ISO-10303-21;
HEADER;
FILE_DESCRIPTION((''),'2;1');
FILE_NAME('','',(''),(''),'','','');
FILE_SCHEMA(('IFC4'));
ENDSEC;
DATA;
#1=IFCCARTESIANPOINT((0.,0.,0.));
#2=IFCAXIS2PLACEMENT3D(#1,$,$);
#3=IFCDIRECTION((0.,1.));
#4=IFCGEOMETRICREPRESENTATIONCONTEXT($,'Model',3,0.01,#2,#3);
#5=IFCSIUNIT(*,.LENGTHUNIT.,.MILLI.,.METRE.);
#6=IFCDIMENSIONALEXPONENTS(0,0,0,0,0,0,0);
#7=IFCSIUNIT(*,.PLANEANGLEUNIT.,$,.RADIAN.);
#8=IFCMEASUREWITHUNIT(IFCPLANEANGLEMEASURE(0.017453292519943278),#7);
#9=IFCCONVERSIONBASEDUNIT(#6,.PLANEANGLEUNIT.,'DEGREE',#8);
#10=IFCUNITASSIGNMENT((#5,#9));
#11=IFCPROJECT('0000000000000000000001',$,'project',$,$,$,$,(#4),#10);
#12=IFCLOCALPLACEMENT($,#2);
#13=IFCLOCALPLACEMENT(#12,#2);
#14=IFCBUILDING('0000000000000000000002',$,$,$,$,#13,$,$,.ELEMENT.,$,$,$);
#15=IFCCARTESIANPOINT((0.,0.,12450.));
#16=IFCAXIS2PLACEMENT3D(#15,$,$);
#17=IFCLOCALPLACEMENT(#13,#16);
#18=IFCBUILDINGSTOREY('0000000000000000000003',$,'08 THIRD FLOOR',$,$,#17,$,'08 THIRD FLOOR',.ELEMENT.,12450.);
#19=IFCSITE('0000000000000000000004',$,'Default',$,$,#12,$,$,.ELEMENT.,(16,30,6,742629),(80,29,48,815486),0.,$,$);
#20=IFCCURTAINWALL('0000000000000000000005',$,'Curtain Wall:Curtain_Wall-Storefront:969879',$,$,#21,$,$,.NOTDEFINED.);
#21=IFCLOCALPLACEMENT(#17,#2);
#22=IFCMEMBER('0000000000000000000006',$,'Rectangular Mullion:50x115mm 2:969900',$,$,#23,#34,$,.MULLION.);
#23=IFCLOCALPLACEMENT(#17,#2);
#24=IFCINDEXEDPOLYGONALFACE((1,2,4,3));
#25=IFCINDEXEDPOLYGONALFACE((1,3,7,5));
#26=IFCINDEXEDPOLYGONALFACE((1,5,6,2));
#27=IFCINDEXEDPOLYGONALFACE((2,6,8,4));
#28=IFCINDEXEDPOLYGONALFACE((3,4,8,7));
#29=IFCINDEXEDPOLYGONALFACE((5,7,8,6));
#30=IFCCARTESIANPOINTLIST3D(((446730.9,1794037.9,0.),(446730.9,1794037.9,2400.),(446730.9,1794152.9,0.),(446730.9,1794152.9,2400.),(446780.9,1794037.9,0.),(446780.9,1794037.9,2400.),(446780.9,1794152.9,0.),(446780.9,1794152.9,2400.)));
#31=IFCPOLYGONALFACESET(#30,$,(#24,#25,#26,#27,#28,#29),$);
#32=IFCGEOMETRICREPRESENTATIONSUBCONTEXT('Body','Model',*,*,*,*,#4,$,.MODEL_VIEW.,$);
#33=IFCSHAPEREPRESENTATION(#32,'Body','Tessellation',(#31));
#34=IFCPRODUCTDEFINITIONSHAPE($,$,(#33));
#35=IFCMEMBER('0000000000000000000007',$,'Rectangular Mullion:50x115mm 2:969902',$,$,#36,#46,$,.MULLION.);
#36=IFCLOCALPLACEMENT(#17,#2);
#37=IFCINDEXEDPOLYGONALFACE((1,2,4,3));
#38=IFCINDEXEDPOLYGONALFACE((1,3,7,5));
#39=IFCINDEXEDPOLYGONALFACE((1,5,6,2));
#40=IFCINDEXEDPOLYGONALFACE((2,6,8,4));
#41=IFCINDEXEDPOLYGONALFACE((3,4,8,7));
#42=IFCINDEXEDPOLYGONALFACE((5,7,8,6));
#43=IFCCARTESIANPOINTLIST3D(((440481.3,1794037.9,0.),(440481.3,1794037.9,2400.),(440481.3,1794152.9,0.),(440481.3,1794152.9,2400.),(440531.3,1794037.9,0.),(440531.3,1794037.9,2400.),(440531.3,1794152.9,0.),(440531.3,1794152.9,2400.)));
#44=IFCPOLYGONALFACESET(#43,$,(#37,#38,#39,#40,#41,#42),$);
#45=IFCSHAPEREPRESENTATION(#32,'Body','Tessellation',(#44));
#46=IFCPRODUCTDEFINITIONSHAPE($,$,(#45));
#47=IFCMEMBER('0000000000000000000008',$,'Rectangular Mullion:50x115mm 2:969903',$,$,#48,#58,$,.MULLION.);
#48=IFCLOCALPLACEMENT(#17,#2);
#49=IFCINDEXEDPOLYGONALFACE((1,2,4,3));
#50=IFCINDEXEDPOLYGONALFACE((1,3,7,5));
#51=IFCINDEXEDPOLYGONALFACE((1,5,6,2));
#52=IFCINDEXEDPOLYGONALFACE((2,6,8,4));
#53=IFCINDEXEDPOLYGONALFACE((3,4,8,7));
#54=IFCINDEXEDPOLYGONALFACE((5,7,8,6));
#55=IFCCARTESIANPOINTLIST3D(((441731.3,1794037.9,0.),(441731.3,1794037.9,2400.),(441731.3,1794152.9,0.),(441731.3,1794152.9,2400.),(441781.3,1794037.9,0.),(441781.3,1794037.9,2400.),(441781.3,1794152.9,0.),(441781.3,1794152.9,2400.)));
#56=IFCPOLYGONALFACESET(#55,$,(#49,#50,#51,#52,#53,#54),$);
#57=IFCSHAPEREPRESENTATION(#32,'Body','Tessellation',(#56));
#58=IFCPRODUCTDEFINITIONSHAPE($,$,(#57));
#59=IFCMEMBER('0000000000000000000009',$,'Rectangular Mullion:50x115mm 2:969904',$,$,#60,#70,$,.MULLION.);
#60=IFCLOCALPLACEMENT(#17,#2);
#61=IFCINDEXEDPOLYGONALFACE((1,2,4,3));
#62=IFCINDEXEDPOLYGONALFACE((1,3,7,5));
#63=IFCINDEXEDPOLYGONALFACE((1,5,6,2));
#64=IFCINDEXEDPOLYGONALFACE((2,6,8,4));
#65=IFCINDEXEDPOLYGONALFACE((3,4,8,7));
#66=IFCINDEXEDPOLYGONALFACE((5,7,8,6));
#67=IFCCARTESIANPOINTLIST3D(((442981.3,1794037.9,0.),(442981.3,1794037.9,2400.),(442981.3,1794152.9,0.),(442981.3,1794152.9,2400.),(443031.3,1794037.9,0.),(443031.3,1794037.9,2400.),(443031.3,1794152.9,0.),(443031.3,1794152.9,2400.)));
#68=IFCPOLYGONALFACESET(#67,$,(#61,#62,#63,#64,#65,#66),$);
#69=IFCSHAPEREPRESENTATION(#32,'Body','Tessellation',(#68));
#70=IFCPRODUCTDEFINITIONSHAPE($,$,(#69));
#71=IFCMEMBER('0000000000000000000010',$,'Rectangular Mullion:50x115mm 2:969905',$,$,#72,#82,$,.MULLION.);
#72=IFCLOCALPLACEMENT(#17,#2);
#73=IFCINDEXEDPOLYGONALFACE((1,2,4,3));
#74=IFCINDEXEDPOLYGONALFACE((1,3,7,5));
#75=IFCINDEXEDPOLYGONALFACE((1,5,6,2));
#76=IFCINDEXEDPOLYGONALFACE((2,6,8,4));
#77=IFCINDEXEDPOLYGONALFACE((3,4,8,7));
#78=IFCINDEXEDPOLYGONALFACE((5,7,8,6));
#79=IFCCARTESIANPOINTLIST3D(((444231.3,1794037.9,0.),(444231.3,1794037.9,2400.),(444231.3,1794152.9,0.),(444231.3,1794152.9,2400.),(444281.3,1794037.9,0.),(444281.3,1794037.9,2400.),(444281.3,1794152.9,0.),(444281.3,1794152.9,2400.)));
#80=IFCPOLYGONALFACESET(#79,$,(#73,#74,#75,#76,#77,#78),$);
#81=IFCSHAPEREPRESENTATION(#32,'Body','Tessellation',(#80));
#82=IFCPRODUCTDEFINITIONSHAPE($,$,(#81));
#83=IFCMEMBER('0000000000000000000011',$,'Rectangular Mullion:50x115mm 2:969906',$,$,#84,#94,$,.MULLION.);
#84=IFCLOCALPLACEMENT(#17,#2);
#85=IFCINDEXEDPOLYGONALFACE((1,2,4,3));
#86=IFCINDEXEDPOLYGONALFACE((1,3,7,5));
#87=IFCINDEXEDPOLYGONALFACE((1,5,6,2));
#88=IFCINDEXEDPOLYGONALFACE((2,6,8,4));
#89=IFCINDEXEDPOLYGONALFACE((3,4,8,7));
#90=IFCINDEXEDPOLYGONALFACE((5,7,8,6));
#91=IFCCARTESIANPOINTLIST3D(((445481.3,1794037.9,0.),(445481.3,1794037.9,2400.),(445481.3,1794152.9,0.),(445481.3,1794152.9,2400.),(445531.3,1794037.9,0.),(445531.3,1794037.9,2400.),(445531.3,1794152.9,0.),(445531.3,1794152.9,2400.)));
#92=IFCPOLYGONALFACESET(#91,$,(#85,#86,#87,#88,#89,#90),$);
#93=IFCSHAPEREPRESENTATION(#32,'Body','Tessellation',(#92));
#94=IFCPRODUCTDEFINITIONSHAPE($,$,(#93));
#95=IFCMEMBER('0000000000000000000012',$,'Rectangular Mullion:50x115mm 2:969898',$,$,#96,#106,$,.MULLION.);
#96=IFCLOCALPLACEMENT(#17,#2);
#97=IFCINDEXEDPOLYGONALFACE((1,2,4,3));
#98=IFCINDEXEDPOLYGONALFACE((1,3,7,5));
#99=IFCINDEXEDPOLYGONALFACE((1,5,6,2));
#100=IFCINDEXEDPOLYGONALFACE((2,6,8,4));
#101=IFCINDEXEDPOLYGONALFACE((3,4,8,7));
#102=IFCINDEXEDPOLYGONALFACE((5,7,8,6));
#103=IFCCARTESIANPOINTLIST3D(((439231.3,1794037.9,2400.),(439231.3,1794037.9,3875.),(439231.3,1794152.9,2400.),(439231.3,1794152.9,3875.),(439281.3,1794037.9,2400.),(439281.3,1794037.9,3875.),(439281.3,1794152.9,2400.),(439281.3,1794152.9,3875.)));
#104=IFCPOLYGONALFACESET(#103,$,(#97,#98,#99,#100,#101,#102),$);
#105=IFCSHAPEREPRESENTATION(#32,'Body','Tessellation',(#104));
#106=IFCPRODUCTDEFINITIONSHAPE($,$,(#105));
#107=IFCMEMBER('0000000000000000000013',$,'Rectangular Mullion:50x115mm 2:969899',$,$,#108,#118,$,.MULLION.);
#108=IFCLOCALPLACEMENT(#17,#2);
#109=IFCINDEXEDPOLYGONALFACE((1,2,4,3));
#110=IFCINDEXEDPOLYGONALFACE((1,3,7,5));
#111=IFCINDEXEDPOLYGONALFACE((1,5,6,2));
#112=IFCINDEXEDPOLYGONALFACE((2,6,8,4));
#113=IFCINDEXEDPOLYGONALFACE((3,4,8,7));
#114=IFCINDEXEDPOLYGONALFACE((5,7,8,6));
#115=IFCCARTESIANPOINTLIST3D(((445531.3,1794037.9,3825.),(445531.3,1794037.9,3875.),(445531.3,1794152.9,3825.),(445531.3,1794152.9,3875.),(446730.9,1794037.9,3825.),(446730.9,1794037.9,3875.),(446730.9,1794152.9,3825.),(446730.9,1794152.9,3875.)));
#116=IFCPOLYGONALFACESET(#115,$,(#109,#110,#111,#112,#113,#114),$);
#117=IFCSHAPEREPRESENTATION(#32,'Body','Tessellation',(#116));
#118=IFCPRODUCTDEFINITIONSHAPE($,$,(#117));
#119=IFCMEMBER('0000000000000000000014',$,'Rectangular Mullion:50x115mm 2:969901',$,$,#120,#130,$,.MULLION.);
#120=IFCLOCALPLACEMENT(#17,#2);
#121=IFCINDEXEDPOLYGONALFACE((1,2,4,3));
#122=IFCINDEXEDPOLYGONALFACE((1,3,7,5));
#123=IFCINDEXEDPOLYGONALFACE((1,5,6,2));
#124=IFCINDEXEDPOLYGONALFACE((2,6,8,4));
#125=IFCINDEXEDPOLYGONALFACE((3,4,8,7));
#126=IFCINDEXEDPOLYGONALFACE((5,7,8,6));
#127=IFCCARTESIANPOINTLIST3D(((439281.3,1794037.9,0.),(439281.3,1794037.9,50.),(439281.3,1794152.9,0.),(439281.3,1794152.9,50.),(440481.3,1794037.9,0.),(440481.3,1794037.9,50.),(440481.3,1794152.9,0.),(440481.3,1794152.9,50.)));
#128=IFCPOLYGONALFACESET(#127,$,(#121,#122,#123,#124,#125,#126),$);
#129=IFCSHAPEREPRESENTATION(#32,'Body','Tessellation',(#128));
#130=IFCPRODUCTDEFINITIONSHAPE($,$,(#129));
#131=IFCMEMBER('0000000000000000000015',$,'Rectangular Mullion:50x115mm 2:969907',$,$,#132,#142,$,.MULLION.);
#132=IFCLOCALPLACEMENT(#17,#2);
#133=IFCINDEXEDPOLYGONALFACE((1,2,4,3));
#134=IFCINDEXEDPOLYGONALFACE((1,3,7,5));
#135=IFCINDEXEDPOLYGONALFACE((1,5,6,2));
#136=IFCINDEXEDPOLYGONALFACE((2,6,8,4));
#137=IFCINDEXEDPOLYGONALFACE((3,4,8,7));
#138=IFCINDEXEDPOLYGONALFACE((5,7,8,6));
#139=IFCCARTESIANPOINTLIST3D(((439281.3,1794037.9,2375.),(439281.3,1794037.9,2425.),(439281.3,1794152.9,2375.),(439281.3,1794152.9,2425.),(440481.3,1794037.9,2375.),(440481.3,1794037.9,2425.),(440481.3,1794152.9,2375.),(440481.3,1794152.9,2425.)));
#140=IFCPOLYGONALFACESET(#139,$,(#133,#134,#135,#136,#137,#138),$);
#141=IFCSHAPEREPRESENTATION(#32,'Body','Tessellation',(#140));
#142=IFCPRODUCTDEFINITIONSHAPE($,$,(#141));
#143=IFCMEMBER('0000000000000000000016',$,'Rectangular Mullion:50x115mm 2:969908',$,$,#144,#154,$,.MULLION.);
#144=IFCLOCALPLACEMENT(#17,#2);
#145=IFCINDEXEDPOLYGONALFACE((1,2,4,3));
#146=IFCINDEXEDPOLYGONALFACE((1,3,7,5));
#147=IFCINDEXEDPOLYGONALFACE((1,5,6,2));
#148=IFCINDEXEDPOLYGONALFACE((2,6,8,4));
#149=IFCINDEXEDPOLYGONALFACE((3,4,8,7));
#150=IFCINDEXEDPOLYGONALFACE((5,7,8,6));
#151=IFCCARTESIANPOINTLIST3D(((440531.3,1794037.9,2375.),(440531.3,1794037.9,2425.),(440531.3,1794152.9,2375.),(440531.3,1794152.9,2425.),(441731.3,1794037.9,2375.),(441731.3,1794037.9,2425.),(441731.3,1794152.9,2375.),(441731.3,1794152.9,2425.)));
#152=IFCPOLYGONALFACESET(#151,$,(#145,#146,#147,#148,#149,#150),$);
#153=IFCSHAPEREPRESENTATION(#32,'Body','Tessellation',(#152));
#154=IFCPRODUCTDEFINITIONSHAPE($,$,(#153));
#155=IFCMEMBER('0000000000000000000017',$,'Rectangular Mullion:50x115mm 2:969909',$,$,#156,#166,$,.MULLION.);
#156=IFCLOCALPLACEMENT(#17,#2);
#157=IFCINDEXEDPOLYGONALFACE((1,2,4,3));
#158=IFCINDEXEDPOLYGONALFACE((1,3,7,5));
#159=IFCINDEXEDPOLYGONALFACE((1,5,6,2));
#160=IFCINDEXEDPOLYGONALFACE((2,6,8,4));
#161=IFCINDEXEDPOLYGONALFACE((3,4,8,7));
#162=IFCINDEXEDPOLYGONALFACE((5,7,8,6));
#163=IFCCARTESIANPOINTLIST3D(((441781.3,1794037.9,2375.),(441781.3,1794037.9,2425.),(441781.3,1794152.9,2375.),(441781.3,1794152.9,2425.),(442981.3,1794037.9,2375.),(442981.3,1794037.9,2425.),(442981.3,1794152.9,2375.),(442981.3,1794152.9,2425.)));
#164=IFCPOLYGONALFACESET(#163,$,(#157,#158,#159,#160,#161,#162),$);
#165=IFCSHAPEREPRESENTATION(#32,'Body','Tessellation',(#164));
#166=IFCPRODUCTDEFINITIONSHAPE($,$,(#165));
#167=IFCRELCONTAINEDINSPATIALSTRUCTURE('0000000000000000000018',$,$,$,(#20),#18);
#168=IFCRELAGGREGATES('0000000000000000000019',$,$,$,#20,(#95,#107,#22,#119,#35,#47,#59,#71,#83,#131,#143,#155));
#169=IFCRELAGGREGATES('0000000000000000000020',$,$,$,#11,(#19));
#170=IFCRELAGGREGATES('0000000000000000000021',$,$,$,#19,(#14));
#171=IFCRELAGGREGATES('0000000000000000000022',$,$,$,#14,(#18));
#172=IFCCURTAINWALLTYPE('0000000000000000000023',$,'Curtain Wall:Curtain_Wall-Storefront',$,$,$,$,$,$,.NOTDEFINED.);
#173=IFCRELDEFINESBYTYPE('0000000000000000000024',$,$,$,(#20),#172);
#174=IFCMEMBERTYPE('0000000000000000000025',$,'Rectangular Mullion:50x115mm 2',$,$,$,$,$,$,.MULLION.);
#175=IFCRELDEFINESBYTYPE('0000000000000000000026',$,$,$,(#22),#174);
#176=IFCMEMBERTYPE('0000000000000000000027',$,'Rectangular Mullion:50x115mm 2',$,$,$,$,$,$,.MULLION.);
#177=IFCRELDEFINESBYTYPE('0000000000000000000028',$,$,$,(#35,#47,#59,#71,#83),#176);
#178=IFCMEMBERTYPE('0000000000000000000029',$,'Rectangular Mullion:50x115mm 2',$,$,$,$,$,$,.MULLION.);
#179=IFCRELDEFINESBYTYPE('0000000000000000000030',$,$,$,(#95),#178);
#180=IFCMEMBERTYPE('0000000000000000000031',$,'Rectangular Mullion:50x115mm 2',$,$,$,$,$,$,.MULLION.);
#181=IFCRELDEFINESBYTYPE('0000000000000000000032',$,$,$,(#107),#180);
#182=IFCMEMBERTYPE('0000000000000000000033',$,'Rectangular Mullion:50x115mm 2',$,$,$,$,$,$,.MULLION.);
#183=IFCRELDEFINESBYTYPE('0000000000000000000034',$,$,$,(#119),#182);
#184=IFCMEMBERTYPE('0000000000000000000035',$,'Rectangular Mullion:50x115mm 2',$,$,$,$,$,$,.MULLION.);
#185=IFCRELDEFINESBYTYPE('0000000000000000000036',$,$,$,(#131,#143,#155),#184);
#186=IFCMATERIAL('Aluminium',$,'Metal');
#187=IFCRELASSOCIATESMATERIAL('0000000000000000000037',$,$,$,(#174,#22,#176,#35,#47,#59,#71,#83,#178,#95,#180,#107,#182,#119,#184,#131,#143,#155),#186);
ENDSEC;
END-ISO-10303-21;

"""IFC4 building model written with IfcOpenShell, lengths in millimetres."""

from ifc_helpers import new_model, entity, si_unit, converted_unit, direction, frame, origin, place, context, subcontext, project, spatial, indexed_curve, outline, extrude, source, transform, mapped, material, type_object, type_shapes, element, aggregate, save


model = new_model("IFC4")

# Units and contexts
model_context = context("Model", 3, precision=0.01, world=origin(), true_north=direction((0.0, 1.0)))
body_context = subcontext(model_context, "Body", "Model", "MODEL_VIEW")
ifc_project = project(units=[si_unit("LENGTHUNIT", "METRE", prefix="MILLI"), converted_unit("PLANEANGLEUNIT", "DEGREE", entity("IfcPlaneAngleMeasure", 0.017453292519943278), si_unit("PLANEANGLEUNIT", "RADIAN"), dimensions=[0, 0, 0, 0, 0, 0, 0])], contexts=[model_context])

# Site, building, storey
site_placement = place(None, origin())
site = spatial("IfcSite", under=ifc_project, at=site_placement, Name="Default", CompositionType="ELEMENT", RefLatitude=(16, 30, 6, 742629), RefLongitude=(80, 29, 48, 815486), RefElevation=0.0)
building_placement = place(site_placement, origin())
building = spatial("IfcBuilding", under=site, at=building_placement, CompositionType="ELEMENT")
storey_placement = place(building_placement, frame((0.0, 0.0, 12450.0)))
storey = spatial("IfcBuildingStorey", under=building, at=storey_placement, Name="08 THIRD FLOOR", LongName="08 THIRD FLOOR", CompositionType="ELEMENT", Elevation=12450.0)

# Curtain wall, members
curtain_wall_type = type_object("IfcCurtainWallType", Name="Curtain Wall:Curtain_Wall-Storefront", PredefinedType="NOTDEFINED")
curtain_wall_placement = place(storey_placement, frame((0.0, 0.0, -12450.0)))
curtain_wall = element("IfcCurtainWall", 1, at=curtain_wall_placement, inside=storey, type_object=curtain_wall_type, Name="Curtain Wall:Curtain_Wall-Storefront:969879", PredefinedType="NOTDEFINED")
ifc_material_1 = material(Name="Aluminium", Category="Metal")
member_type_1 = type_object("IfcMemberType", Name="Rectangular Mullion:50x115mm 2", PredefinedType="MULLION", material=ifc_material_1)
shared_shape_1 = source(origin(), body_context, "Body", "SweptSolid", [
    extrude(outline(indexed_curve([(-25.0, -57.5), (25.0, -57.5), (25.0, 57.5), (-25.0, 57.5), (-25.0, -57.5)], self_intersect=False)), frame((-25.0, 0.0, -2400.0), z_axis=(0.0, 0.0, 1.0), x_axis=(-1.0, 0.0, 0.0)), (0.0, 0.0, 1.0), 2400.0),
])
type_shapes(member_type_1, [shared_shape_1])
member_1_placement = place(curtain_wall_placement, frame((446780.9, 1794095.4, 12450.0), z_axis=(0.0, 0.0, -1.0), x_axis=(1.0, 0.0, 0.0)))
member_1 = element("IfcMember", 2, at=member_1_placement, type_object=member_type_1, material=ifc_material_1, Name="Rectangular Mullion:50x115mm 2:969900", PredefinedType="MULLION", context=body_context, shape_type="MappedRepresentation", body=[
    mapped(shared_shape_1, transform((0.0, 0.0, 0.0), scale=1.0)),
])
member_type_2 = type_object("IfcMemberType", Name="Rectangular Mullion:50x115mm 2", PredefinedType="MULLION", material=ifc_material_1)
shared_shape_2 = source(origin(), body_context, "Body", "SweptSolid", [
    extrude(outline(indexed_curve([(-25.0, -57.5), (25.0, -57.5), (25.0, 57.5), (-25.0, 57.5), (-25.0, -57.5)], self_intersect=False)), frame((0.0, 0.0, -2400.0), z_axis=(0.0, 0.0, 1.0), x_axis=(-1.0, 0.0, 0.0)), (0.0, 0.0, 1.0), 2400.0),
])
type_shapes(member_type_2, [shared_shape_2])
member_2_placement = place(curtain_wall_placement, frame((440506.3, 1794095.4, 12450.0), z_axis=(0.0, 0.0, -1.0), x_axis=(1.0, 0.0, 0.0)))
member_2 = element("IfcMember", 3, at=member_2_placement, type_object=member_type_2, material=ifc_material_1, Name="Rectangular Mullion:50x115mm 2:969902", PredefinedType="MULLION", context=body_context, shape_type="MappedRepresentation", body=[
    mapped(shared_shape_2, transform((0.0, 0.0, 0.0), scale=1.0)),
])
member_3_placement = place(curtain_wall_placement, frame((441756.3, 1794095.4, 12450.0), z_axis=(0.0, 0.0, -1.0), x_axis=(1.0, 0.0, 0.0)))
member_3 = element("IfcMember", 4, at=member_3_placement, type_object=member_type_2, material=ifc_material_1, Name="Rectangular Mullion:50x115mm 2:969903", PredefinedType="MULLION", context=body_context, shape_type="MappedRepresentation", body=[
    mapped(shared_shape_2, transform((0.0, 0.0, 0.0), scale=1.0)),
])
member_4_placement = place(curtain_wall_placement, frame((443006.3, 1794095.4, 12450.0), z_axis=(0.0, 0.0, -1.0), x_axis=(1.0, 0.0, 0.0)))
member_4 = element("IfcMember", 5, at=member_4_placement, type_object=member_type_2, material=ifc_material_1, Name="Rectangular Mullion:50x115mm 2:969904", PredefinedType="MULLION", context=body_context, shape_type="MappedRepresentation", body=[
    mapped(shared_shape_2, transform((0.0, 0.0, 0.0), scale=1.0)),
])
member_5_placement = place(curtain_wall_placement, frame((444256.3, 1794095.4, 12450.0), z_axis=(0.0, 0.0, -1.0), x_axis=(1.0, 0.0, 0.0)))
member_5 = element("IfcMember", 6, at=member_5_placement, type_object=member_type_2, material=ifc_material_1, Name="Rectangular Mullion:50x115mm 2:969905", PredefinedType="MULLION", context=body_context, shape_type="MappedRepresentation", body=[
    mapped(shared_shape_2, transform((0.0, 0.0, 0.0), scale=1.0)),
])
member_6_placement = place(curtain_wall_placement, frame((445506.3, 1794095.4, 12450.0), z_axis=(0.0, 0.0, -1.0), x_axis=(1.0, 0.0, 0.0)))
member_6 = element("IfcMember", 7, at=member_6_placement, type_object=member_type_2, material=ifc_material_1, Name="Rectangular Mullion:50x115mm 2:969906", PredefinedType="MULLION", context=body_context, shape_type="MappedRepresentation", body=[
    mapped(shared_shape_2, transform((0.0, 0.0, 0.0), scale=1.0)),
])
member_type_3 = type_object("IfcMemberType", Name="Rectangular Mullion:50x115mm 2", PredefinedType="MULLION", material=ifc_material_1)
shared_shape_3 = source(origin(), body_context, "Body", "SweptSolid", [
    extrude(outline(indexed_curve([(-25.0, -57.5), (25.0, -57.5), (25.0, 57.5), (-25.0, 57.5), (-25.0, -57.5)], self_intersect=False)), frame((-25.0, 0.0, -1475.0), z_axis=(0.0, 0.0, 1.0), x_axis=(-1.0, 0.0, 0.0)), (0.0, 0.0, 1.0), 1475.0),
])
type_shapes(member_type_3, [shared_shape_3])
member_7_placement = place(curtain_wall_placement, frame((439231.3, 1794095.4, 16325.0), z_axis=(0.0, 0.0, 1.0), x_axis=(-1.0, 0.0, 0.0)))
member_7 = element("IfcMember", 8, at=member_7_placement, type_object=member_type_3, material=ifc_material_1, Name="Rectangular Mullion:50x115mm 2:969898", PredefinedType="MULLION", context=body_context, shape_type="MappedRepresentation", body=[
    mapped(shared_shape_3, transform((0.0, 0.0, 0.0), scale=1.0)),
])
member_type_4 = type_object("IfcMemberType", Name="Rectangular Mullion:50x115mm 2", PredefinedType="MULLION", material=ifc_material_1)
shared_shape_4 = source(origin(), body_context, "Body", "SweptSolid", [
    extrude(outline(indexed_curve([(-25.0, -57.5), (25.0, -57.5), (25.0, 57.5), (-25.0, 57.5), (-25.0, -57.5)], self_intersect=False)), frame((-25.0, 0.0, -1199.6), z_axis=(0.0, 0.0, 1.0), x_axis=(-1.0, 0.0, 0.0)), (0.0, 0.0, 1.0), 1199.6),
])
type_shapes(member_type_4, [shared_shape_4])
member_8_placement = place(curtain_wall_placement, frame((446730.9, 1794095.4, 16325.0), z_axis=(1.0, 0.0, 0.0), x_axis=(0.0, 0.0, 1.0)))
member_8 = element("IfcMember", 9, at=member_8_placement, type_object=member_type_4, material=ifc_material_1, Name="Rectangular Mullion:50x115mm 2:969899", PredefinedType="MULLION", context=body_context, shape_type="MappedRepresentation", body=[
    mapped(shared_shape_4, transform((0.0, 0.0, 0.0), scale=1.0)),
])
member_type_5 = type_object("IfcMemberType", Name="Rectangular Mullion:50x115mm 2", PredefinedType="MULLION", material=ifc_material_1)
shared_shape_5 = source(origin(), body_context, "Body", "SweptSolid", [
    extrude(outline(indexed_curve([(-25.0, -57.5), (25.0, -57.5), (25.0, 57.5), (-25.0, 57.5), (-25.0, -57.5)], self_intersect=False)), frame((-25.0, 0.0, -1200.0), z_axis=(0.0, 0.0, 1.0), x_axis=(-1.0, 0.0, 0.0)), (0.0, 0.0, 1.0), 1200.0),
])
type_shapes(member_type_5, [shared_shape_5])
member_9_placement = place(curtain_wall_placement, frame((439281.3, 1794095.4, 12450.0), z_axis=(-1.0, 0.0, 0.0), x_axis=(0.0, 0.0, -1.0)))
member_9 = element("IfcMember", 10, at=member_9_placement, type_object=member_type_5, material=ifc_material_1, Name="Rectangular Mullion:50x115mm 2:969901", PredefinedType="MULLION", context=body_context, shape_type="MappedRepresentation", body=[
    mapped(shared_shape_5, transform((0.0, 0.0, 0.0), scale=1.0)),
])
member_type_6 = type_object("IfcMemberType", Name="Rectangular Mullion:50x115mm 2", PredefinedType="MULLION", material=ifc_material_1)
shared_shape_6 = source(origin(), body_context, "Body", "SweptSolid", [
    extrude(outline(indexed_curve([(-25.0, -57.5), (25.0, -57.5), (25.0, 57.5), (-25.0, 57.5), (-25.0, -57.5)], self_intersect=False)), frame((0.0, 0.0, -1200.0), z_axis=(0.0, 0.0, 1.0), x_axis=(-1.0, 0.0, 0.0)), (0.0, 0.0, 1.0), 1200.0),
])
type_shapes(member_type_6, [shared_shape_6])
member_10_placement = place(curtain_wall_placement, frame((440481.3, 1794095.4, 14850.0), z_axis=(1.0, 0.0, 0.0), x_axis=(0.0, 0.0, 1.0)))
member_10 = element("IfcMember", 11, at=member_10_placement, type_object=member_type_6, material=ifc_material_1, Name="Rectangular Mullion:50x115mm 2:969907", PredefinedType="MULLION", context=body_context, shape_type="MappedRepresentation", body=[
    mapped(shared_shape_6, transform((0.0, 0.0, 0.0), scale=1.0)),
])
member_11_placement = place(curtain_wall_placement, frame((441731.3, 1794095.4, 14850.0), z_axis=(1.0, 0.0, 0.0), x_axis=(0.0, 0.0, 1.0)))
member_11 = element("IfcMember", 12, at=member_11_placement, type_object=member_type_6, material=ifc_material_1, Name="Rectangular Mullion:50x115mm 2:969908", PredefinedType="MULLION", context=body_context, shape_type="MappedRepresentation", body=[
    mapped(shared_shape_6, transform((0.0, 0.0, 0.0), scale=1.0)),
])
member_12_placement = place(curtain_wall_placement, frame((442981.3, 1794095.4, 14850.0), z_axis=(1.0, 0.0, 0.0), x_axis=(0.0, 0.0, 1.0)))
member_12 = element("IfcMember", 13, at=member_12_placement, type_object=member_type_6, material=ifc_material_1, Name="Rectangular Mullion:50x115mm 2:969909", PredefinedType="MULLION", context=body_context, shape_type="MappedRepresentation", body=[
    mapped(shared_shape_6, transform((0.0, 0.0, 0.0), scale=1.0)),
])

aggregate(curtain_wall, [member_7, member_8, member_1, member_9, member_2, member_3, member_4, member_5, member_6, member_10, member_11, member_12])

save(model, "model.ifc")
